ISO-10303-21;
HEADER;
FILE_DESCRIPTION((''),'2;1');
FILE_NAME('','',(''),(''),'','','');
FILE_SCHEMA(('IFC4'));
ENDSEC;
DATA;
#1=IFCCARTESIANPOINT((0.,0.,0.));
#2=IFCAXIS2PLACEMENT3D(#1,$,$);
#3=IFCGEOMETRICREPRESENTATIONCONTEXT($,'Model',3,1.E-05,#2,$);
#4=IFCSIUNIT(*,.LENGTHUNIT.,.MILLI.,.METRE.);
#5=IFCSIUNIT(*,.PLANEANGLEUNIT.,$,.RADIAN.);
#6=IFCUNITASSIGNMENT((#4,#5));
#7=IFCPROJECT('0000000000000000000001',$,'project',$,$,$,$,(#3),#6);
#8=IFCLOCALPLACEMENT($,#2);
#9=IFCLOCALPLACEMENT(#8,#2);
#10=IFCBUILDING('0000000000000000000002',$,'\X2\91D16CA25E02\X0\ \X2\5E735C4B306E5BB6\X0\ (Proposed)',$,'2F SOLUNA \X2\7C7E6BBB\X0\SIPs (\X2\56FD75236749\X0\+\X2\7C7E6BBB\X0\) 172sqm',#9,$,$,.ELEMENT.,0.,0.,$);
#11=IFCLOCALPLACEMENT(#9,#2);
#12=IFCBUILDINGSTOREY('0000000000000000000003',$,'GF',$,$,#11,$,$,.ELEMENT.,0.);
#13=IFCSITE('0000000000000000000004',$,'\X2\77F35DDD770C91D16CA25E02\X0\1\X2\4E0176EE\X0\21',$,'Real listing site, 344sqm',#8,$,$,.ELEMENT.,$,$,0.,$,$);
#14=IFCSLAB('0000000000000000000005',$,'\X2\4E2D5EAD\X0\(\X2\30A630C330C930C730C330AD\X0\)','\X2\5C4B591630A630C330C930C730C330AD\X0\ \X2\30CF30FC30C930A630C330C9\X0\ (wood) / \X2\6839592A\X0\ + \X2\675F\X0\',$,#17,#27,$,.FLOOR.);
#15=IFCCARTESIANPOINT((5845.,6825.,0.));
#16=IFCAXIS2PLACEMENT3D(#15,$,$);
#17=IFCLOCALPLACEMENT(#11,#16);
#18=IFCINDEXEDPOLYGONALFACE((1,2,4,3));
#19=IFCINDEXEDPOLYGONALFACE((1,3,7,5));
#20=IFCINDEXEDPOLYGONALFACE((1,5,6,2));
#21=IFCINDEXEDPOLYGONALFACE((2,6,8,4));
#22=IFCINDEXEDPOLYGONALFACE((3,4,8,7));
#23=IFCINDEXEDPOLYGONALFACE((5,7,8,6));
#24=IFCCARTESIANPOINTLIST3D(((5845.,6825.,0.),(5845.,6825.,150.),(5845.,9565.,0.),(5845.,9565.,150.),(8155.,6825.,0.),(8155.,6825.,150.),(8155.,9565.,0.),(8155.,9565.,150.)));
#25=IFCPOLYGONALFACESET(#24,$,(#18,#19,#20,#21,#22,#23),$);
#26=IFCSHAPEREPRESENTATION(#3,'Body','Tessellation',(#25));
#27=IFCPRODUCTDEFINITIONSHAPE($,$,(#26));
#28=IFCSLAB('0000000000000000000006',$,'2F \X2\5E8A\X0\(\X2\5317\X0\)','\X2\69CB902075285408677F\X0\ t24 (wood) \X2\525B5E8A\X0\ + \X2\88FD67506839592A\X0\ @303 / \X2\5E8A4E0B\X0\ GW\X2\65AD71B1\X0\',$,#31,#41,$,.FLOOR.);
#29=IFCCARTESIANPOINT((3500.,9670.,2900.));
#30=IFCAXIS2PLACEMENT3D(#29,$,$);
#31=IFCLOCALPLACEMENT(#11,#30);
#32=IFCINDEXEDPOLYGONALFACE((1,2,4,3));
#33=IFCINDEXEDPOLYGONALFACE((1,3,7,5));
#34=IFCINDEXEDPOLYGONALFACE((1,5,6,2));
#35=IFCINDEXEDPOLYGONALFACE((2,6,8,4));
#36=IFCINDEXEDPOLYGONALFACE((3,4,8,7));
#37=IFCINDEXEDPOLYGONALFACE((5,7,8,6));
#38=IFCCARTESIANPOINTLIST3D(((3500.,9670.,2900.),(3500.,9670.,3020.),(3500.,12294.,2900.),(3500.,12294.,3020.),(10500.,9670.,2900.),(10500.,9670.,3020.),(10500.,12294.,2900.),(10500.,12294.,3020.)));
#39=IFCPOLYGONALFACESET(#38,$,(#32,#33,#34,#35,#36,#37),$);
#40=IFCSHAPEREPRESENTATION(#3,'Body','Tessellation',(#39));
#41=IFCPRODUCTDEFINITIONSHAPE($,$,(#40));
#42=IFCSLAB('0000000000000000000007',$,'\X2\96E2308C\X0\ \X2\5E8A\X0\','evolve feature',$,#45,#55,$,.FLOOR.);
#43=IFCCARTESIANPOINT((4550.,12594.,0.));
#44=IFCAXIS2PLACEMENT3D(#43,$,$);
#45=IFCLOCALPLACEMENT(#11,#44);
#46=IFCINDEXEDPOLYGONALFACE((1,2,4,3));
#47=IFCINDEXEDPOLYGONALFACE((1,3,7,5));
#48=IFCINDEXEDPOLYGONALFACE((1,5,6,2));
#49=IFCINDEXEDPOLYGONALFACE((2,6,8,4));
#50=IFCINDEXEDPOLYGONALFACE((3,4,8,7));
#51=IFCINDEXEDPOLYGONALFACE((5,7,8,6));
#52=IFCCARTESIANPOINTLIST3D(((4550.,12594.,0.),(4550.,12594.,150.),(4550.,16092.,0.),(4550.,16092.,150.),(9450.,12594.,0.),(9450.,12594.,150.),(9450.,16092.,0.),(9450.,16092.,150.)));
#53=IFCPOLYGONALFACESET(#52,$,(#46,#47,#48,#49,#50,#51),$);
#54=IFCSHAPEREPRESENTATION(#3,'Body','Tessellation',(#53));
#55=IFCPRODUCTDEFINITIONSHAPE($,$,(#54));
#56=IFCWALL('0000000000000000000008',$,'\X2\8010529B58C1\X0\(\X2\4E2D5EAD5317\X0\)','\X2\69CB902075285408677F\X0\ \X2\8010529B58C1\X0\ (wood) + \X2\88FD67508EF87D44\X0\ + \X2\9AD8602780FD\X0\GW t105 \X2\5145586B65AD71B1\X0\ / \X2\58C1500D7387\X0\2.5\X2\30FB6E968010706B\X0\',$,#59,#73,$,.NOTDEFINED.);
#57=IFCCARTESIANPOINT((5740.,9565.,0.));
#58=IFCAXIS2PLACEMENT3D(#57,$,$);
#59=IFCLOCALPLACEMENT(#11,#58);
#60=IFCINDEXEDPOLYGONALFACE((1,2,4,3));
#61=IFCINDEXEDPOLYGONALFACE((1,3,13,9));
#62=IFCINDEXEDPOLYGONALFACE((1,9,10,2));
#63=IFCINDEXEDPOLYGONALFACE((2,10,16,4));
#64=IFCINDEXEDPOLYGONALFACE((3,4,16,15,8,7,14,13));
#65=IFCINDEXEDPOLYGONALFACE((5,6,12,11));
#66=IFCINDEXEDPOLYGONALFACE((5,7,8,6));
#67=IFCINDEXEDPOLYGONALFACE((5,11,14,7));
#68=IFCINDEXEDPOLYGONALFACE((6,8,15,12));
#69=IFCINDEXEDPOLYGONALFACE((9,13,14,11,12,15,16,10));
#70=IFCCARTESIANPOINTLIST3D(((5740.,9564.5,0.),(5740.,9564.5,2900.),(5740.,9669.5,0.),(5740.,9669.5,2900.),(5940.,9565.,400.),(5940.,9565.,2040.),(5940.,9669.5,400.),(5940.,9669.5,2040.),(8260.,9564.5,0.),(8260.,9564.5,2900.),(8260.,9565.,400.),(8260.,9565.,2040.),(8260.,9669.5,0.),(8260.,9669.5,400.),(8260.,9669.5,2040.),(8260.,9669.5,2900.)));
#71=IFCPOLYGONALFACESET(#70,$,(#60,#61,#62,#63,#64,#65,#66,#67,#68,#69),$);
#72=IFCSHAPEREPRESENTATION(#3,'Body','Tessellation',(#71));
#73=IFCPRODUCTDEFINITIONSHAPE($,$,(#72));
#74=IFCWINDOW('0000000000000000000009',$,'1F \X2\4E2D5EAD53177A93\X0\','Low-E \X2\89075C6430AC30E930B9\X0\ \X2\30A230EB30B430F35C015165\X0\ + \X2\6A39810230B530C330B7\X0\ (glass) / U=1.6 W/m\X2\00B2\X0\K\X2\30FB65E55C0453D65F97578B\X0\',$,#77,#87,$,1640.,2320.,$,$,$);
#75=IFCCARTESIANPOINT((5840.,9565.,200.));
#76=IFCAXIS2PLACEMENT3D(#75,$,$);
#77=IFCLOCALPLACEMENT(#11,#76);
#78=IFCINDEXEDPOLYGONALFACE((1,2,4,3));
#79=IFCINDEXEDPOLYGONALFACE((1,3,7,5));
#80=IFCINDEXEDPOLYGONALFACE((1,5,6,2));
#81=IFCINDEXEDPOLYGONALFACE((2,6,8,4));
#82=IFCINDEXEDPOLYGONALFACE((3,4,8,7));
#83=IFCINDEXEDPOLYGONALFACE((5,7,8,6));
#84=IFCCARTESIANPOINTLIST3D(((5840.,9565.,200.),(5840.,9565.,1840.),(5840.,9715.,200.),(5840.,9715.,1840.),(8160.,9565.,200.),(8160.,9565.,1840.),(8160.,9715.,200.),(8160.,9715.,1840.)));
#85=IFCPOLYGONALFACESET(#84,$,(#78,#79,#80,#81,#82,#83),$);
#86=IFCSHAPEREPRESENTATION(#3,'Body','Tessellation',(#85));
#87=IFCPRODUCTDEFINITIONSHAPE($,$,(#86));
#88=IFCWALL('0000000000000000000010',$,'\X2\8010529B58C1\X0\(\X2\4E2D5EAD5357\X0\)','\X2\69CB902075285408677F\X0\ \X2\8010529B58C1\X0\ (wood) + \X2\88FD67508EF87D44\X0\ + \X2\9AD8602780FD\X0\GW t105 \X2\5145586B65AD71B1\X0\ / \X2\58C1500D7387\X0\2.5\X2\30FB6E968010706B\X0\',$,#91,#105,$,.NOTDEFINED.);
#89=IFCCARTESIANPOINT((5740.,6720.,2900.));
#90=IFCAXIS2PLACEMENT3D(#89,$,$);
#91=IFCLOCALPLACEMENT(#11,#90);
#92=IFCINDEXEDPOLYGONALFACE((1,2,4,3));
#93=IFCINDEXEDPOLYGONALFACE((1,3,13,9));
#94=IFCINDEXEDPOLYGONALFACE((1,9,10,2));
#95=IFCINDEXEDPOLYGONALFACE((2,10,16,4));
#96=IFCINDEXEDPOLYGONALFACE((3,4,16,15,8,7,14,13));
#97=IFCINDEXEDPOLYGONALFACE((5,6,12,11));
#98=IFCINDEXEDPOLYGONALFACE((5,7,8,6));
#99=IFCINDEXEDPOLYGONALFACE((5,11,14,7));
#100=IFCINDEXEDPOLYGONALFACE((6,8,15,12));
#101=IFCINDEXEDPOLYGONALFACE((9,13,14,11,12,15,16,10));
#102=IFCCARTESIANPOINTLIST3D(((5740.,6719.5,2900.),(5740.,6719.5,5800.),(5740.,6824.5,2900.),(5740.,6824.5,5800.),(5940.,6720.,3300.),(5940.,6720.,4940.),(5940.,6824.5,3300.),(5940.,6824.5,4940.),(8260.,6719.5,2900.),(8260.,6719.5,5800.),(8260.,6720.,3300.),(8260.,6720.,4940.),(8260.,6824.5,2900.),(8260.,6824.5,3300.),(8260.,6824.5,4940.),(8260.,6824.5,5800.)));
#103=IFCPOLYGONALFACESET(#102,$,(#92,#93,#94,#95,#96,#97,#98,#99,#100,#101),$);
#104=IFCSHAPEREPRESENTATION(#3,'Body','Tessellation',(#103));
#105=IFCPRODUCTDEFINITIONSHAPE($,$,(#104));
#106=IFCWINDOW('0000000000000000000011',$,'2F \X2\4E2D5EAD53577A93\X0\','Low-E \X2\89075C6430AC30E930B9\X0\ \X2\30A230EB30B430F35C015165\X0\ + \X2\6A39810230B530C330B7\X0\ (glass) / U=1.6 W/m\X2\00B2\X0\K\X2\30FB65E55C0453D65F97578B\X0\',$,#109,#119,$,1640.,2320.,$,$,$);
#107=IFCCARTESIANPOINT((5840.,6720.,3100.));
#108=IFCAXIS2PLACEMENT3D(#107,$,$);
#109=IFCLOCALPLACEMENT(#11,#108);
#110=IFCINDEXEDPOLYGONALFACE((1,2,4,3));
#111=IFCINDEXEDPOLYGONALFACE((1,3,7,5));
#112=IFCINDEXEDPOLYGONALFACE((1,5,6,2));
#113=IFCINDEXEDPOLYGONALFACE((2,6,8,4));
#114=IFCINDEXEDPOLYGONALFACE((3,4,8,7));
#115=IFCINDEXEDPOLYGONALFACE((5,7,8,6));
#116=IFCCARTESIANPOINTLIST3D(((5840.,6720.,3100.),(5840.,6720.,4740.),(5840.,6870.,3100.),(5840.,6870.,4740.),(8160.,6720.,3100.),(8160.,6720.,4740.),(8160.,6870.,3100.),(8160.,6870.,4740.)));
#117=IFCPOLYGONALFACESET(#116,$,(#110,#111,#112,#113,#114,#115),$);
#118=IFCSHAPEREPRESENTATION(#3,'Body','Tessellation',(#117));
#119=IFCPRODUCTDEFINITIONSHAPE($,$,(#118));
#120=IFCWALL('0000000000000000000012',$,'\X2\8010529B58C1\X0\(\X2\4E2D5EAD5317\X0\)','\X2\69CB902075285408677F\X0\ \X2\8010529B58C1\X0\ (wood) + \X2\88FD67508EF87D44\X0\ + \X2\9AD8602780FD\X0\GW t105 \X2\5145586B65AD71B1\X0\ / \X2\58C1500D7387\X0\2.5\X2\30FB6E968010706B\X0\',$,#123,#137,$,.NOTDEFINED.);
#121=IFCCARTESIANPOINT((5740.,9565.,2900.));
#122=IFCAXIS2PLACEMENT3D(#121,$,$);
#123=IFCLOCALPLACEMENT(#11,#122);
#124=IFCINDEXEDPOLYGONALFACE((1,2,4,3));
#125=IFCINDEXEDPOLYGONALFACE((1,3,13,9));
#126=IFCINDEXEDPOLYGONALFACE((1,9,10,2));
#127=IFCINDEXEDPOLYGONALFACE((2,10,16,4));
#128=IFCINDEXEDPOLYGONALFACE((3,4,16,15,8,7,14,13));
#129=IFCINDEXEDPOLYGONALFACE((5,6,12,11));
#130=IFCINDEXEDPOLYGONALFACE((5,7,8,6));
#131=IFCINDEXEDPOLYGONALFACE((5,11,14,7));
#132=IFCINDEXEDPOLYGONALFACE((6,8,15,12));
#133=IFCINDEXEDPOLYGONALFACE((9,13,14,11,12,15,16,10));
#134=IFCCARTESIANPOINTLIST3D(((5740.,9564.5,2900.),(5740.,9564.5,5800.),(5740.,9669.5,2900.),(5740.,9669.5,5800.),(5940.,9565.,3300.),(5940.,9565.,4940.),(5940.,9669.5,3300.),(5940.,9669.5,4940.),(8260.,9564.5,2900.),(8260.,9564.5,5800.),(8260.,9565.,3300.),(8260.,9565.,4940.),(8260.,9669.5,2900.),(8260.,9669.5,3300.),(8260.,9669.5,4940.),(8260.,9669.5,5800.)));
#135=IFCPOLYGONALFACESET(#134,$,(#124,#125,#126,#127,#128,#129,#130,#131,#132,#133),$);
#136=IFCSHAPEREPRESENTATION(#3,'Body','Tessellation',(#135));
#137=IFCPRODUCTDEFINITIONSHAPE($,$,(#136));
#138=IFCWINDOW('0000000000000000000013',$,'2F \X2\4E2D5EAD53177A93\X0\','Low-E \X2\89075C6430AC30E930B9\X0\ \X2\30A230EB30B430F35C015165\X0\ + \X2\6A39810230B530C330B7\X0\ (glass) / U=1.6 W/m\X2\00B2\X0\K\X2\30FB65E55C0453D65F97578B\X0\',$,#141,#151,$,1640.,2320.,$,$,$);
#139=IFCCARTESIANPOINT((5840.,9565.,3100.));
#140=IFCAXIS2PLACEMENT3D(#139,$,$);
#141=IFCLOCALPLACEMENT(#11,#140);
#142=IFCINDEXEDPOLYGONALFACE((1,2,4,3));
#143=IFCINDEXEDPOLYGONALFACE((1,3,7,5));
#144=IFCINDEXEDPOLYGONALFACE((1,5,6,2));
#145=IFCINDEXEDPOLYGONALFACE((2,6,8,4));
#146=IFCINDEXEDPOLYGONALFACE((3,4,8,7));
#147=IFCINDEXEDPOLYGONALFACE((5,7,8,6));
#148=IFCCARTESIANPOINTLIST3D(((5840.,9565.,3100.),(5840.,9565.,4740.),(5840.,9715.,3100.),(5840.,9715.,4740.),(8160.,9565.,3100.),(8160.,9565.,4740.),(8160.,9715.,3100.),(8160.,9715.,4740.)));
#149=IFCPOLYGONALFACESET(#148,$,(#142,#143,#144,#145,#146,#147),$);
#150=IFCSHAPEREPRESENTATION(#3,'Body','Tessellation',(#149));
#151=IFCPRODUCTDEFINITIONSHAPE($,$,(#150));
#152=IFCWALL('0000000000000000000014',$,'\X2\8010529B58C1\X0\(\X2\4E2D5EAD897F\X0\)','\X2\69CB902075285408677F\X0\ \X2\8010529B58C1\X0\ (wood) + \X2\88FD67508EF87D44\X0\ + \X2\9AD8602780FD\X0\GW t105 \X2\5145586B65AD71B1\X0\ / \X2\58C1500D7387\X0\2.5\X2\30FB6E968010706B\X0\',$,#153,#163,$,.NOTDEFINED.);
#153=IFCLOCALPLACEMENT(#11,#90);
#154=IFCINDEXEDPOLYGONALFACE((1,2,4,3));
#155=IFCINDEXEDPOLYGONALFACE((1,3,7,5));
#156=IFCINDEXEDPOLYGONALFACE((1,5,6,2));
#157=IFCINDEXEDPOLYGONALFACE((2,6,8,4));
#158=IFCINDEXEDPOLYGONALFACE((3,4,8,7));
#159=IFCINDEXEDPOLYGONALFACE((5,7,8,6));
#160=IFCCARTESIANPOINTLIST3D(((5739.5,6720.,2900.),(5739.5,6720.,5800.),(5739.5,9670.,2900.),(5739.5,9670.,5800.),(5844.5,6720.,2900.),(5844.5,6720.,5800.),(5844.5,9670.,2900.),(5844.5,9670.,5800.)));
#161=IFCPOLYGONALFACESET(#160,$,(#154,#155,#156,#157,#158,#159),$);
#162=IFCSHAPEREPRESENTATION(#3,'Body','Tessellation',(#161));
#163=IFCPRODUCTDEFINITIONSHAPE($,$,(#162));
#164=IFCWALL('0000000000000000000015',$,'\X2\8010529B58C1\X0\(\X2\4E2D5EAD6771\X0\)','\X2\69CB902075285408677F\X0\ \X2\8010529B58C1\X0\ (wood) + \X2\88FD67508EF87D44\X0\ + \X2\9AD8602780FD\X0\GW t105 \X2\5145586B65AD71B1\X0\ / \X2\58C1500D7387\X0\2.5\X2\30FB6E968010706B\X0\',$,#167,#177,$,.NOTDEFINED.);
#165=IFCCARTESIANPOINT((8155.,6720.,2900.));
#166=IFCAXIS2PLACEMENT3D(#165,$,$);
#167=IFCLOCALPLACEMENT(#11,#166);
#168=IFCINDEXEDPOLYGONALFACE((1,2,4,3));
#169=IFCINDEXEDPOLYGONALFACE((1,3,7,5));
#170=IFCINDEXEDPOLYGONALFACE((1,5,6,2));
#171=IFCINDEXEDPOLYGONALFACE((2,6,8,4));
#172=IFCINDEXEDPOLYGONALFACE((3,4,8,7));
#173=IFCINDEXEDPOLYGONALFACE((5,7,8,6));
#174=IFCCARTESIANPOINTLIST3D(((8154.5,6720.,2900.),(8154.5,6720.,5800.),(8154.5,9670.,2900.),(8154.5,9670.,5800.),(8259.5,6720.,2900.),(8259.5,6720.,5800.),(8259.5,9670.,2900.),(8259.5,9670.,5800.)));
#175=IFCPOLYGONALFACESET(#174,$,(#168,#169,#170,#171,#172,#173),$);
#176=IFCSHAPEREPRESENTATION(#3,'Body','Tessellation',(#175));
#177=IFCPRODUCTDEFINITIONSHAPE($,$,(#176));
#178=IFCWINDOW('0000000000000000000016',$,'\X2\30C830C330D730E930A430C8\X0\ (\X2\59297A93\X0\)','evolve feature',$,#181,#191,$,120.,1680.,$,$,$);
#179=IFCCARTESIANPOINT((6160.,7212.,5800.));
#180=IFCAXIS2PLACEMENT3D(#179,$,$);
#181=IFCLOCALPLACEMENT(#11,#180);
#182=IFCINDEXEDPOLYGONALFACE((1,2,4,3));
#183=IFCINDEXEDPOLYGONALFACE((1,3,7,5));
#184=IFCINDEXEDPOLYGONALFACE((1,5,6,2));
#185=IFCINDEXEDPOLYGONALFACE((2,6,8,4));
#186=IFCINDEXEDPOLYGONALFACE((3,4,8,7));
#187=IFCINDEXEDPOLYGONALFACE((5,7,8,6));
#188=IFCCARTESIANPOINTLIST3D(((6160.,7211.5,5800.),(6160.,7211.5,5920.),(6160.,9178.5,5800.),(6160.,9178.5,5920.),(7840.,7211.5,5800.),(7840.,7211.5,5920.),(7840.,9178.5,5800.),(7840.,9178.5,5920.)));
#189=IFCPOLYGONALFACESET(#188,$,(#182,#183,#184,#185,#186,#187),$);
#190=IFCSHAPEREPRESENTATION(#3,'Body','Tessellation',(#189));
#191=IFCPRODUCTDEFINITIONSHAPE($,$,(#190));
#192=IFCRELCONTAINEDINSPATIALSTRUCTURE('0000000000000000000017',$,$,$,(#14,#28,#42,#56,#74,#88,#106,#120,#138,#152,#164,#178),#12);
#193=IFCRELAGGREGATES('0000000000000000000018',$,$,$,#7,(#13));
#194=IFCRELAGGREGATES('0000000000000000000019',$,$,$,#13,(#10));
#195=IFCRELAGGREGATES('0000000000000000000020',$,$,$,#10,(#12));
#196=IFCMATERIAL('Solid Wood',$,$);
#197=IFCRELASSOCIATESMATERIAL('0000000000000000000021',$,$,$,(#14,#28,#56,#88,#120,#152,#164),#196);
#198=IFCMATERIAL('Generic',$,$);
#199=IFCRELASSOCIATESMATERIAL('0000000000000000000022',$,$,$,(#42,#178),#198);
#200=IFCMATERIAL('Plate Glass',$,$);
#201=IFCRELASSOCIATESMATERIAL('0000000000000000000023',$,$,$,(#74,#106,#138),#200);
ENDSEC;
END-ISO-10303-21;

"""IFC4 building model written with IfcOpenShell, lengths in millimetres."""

from ifc_helpers import new_model, si_unit, frame, frame_2d, origin, place, context, project, spatial, rectangle, extrude, material, element, fill, save


model = new_model("IFC4")

# Units and contexts
model_context = context("Model", 3, precision=1e-05, world=origin())
ifc_project = project(units=[si_unit("LENGTHUNIT", "METRE", prefix="MILLI"), si_unit("PLANEANGLEUNIT", "RADIAN")], contexts=[model_context])

# Site, building, storey
site_placement = place(None, origin())
site = spatial("IfcSite", under=ifc_project, at=site_placement, Name="石川県金沢市1丁目21", ObjectType="Real listing site, 344sqm", CompositionType="ELEMENT", RefElevation=0.0)
building_placement = place(site_placement, origin())
building = spatial("IfcBuilding", under=site, at=building_placement, Name="金沢市 平屋の家 (Proposed)", ObjectType="2F SOLUNA 籾殻SIPs (国産杉+籾殻) 172sqm", CompositionType="ELEMENT", ElevationOfRefHeight=0.0, ElevationOfTerrain=0.0)
storey_placement = place(building_placement, origin())
storey = spatial("IfcBuildingStorey", under=building, at=storey_placement, Name="GF", CompositionType="ELEMENT", Elevation=0.0)

# Slabs
ifc_material_1 = material(Name="Solid Wood")
slab_1_placement = place(storey_placement, frame((5845.0, 6825.0, 0.0)))
element("IfcSlab", 1, at=slab_1_placement, inside=storey, material=ifc_material_1, Name="中庭(ウッドデッキ)", Description="屋外ウッドデッキ ハードウッド (wood) / 根太 + 束", PredefinedType="FLOOR", context=model_context, shape_type="SweptSolid", body=[
    extrude(rectangle(XDim=2310.0, YDim=2740.0, at=frame_2d((1155.0, 1370.0))), frame((5845.0, 6825.0, 0.0)), (0.0, 0.0, 1.0), 150.0),
])
slab_2_placement = place(storey_placement, frame((3500.0, 9670.0, 2900.0)))
element("IfcSlab", 2, at=slab_2_placement, inside=storey, material=ifc_material_1, Name="2F 床(北)", Description="構造用合板 t24 (wood) 剛床 + 製材根太 @303 / 床下 GW断熱", PredefinedType="FLOOR", context=model_context, shape_type="SweptSolid", body=[
    extrude(rectangle(XDim=7000.0, YDim=2624.0, at=frame_2d((3500.0, 1312.0))), frame((3500.0, 9670.0, 2900.0)), (0.0, 0.0, 1.0), 120.0),
])
ifc_material_2 = material(Name="Generic")
slab_3_placement = place(storey_placement, frame((4550.0, 12594.0, 0.0)))
element("IfcSlab", 3, at=slab_3_placement, inside=storey, material=ifc_material_2, Name="離れ 床", Description="evolve feature", PredefinedType="FLOOR", context=model_context, shape_type="SweptSolid", body=[
    extrude(rectangle(XDim=4900.0, YDim=3498.0, at=frame_2d((2450.0, 1749.0))), frame((4550.0, 12594.0, 0.0)), (0.0, 0.0, 1.0), 150.0),
])

# Wall, opening, window
wall_1_placement = place(storey_placement, frame((5740.0, 9565.0, 0.0)))
wall_1 = element("IfcWall", 4, at=wall_1_placement, inside=storey, material=ifc_material_1, Name="耐力壁(中庭北)", Description="構造用合板 耐力壁 (wood) + 製材軸組 + 高性能GW t105 充填断熱 / 壁倍率2.5・準耐火", PredefinedType="NOTDEFINED", context=model_context, shape_type="SweptSolid", body=[
    extrude(rectangle(XDim=2520.0, YDim=105.0, at=frame_2d((1260.0, 52.0))), frame((5740.0, 9565.0, 0.0)), (0.0, 0.0, 1.0), 2900.0),
])
opening_1_placement = place(storey_placement, frame((5840.0, 9565.0, 200.0)))
opening_1 = element("IfcOpeningElement", 5, at=opening_1_placement, cuts=wall_1, PredefinedType="NOTDEFINED", context=model_context, shape_type="SweptSolid", body=[
    extrude(rectangle(XDim=2320.0, YDim=150.0, at=frame_2d((1160.0, 75.0))), frame((5840.0, 9565.0, 200.0)), (0.0, 0.0, 1.0), 1640.0),
])
ifc_material_3 = material(Name="Plate Glass")
window_1_placement = place(storey_placement, frame((5840.0, 9565.0, 200.0)))
window_1 = element("IfcWindow", 6, at=window_1_placement, inside=storey, material=ifc_material_3, Name="1F 中庭北窓", Description="Low-E 複層ガラス アルゴン封入 + 樹脂サッシ (glass) / U=1.6 W/m²K・日射取得型", OverallHeight=1640.0, OverallWidth=2320.0, context=model_context, shape_type="SweptSolid", body=[
    extrude(rectangle(XDim=2320.0, YDim=150.0, at=frame_2d((1160.0, 75.0))), frame((5840.0, 9565.0, 200.0)), (0.0, 0.0, 1.0), 1640.0),
])
fill(opening_1, window_1)

# Walls, openings, windows
wall_2_placement = place(storey_placement, frame((5740.0, 6720.0, 2900.0)))
wall_2 = element("IfcWall", 7, at=wall_2_placement, inside=storey, material=ifc_material_1, Name="耐力壁(中庭南)", Description="構造用合板 耐力壁 (wood) + 製材軸組 + 高性能GW t105 充填断熱 / 壁倍率2.5・準耐火", PredefinedType="NOTDEFINED", context=model_context, shape_type="SweptSolid", body=[
    extrude(rectangle(XDim=2520.0, YDim=105.0, at=frame_2d((1260.0, 52.0))), frame((5740.0, 6720.0, 2900.0)), (0.0, 0.0, 1.0), 2900.0),
])
opening_2_placement = place(storey_placement, frame((5840.0, 6720.0, 3100.0)))
opening_2 = element("IfcOpeningElement", 8, at=opening_2_placement, cuts=wall_2, PredefinedType="NOTDEFINED", context=model_context, shape_type="SweptSolid", body=[
    extrude(rectangle(XDim=2320.0, YDim=150.0, at=frame_2d((1160.0, 75.0))), frame((5840.0, 6720.0, 3100.0)), (0.0, 0.0, 1.0), 1640.0),
])
window_2_placement = place(storey_placement, frame((5840.0, 6720.0, 3100.0)))
window_2 = element("IfcWindow", 9, at=window_2_placement, inside=storey, material=ifc_material_3, Name="2F 中庭南窓", Description="Low-E 複層ガラス アルゴン封入 + 樹脂サッシ (glass) / U=1.6 W/m²K・日射取得型", OverallHeight=1640.0, OverallWidth=2320.0, context=model_context, shape_type="SweptSolid", body=[
    extrude(rectangle(XDim=2320.0, YDim=150.0, at=frame_2d((1160.0, 75.0))), frame((5840.0, 6720.0, 3100.0)), (0.0, 0.0, 1.0), 1640.0),
])
fill(opening_2, window_2)
wall_3_placement = place(storey_placement, frame((5740.0, 9565.0, 2900.0)))
wall_3 = element("IfcWall", 10, at=wall_3_placement, inside=storey, material=ifc_material_1, Name="耐力壁(中庭北)", Description="構造用合板 耐力壁 (wood) + 製材軸組 + 高性能GW t105 充填断熱 / 壁倍率2.5・準耐火", PredefinedType="NOTDEFINED", context=model_context, shape_type="SweptSolid", body=[
    extrude(rectangle(XDim=2520.0, YDim=105.0, at=frame_2d((1260.0, 52.0))), frame((5740.0, 9565.0, 2900.0)), (0.0, 0.0, 1.0), 2900.0),
])
opening_3_placement = place(storey_placement, frame((5840.0, 9565.0, 3100.0)))
opening_3 = element("IfcOpeningElement", 11, at=opening_3_placement, cuts=wall_3, PredefinedType="NOTDEFINED", context=model_context, shape_type="SweptSolid", body=[
    extrude(rectangle(XDim=2320.0, YDim=150.0, at=frame_2d((1160.0, 75.0))), frame((5840.0, 9565.0, 3100.0)), (0.0, 0.0, 1.0), 1640.0),
])
window_3_placement = place(storey_placement, frame((5840.0, 9565.0, 3100.0)))
window_3 = element("IfcWindow", 12, at=window_3_placement, inside=storey, material=ifc_material_3, Name="2F 中庭北窓", Description="Low-E 複層ガラス アルゴン封入 + 樹脂サッシ (glass) / U=1.6 W/m²K・日射取得型", OverallHeight=1640.0, OverallWidth=2320.0, context=model_context, shape_type="SweptSolid", body=[
    extrude(rectangle(XDim=2320.0, YDim=150.0, at=frame_2d((1160.0, 75.0))), frame((5840.0, 9565.0, 3100.0)), (0.0, 0.0, 1.0), 1640.0),
])
fill(opening_3, window_3)

# Walls
wall_4_placement = place(storey_placement, frame((5740.0, 6720.0, 2900.0)))
element("IfcWall", 13, at=wall_4_placement, inside=storey, material=ifc_material_1, Name="耐力壁(中庭西)", Description="構造用合板 耐力壁 (wood) + 製材軸組 + 高性能GW t105 充填断熱 / 壁倍率2.5・準耐火", PredefinedType="NOTDEFINED", context=model_context, shape_type="SweptSolid", body=[
    extrude(rectangle(XDim=105.0, YDim=2950.0, at=frame_2d((52.0, 1475.0))), frame((5740.0, 6720.0, 2900.0)), (0.0, 0.0, 1.0), 2900.0),
])
wall_5_placement = place(storey_placement, frame((8155.0, 6720.0, 2900.0)))
element("IfcWall", 14, at=wall_5_placement, inside=storey, material=ifc_material_1, Name="耐力壁(中庭東)", Description="構造用合板 耐力壁 (wood) + 製材軸組 + 高性能GW t105 充填断熱 / 壁倍率2.5・準耐火", PredefinedType="NOTDEFINED", context=model_context, shape_type="SweptSolid", body=[
    extrude(rectangle(XDim=105.0, YDim=2950.0, at=frame_2d((52.0, 1475.0))), frame((8155.0, 6720.0, 2900.0)), (0.0, 0.0, 1.0), 2900.0),
])

# Window
window_4_placement = place(storey_placement, frame((6160.0, 7212.0, 5800.0)))
element("IfcWindow", 15, at=window_4_placement, inside=storey, material=ifc_material_2, Name="トップライト (天窓)", Description="evolve feature", OverallHeight=120.0, OverallWidth=1680.0, context=model_context, shape_type="SweptSolid", body=[
    extrude(rectangle(XDim=1680.0, YDim=1967.0, at=frame_2d((840.0, 983.0))), frame((6160.0, 7212.0, 5800.0)), (0.0, 0.0, 1.0), 120.0),
])

save(model, "model.ifc")
